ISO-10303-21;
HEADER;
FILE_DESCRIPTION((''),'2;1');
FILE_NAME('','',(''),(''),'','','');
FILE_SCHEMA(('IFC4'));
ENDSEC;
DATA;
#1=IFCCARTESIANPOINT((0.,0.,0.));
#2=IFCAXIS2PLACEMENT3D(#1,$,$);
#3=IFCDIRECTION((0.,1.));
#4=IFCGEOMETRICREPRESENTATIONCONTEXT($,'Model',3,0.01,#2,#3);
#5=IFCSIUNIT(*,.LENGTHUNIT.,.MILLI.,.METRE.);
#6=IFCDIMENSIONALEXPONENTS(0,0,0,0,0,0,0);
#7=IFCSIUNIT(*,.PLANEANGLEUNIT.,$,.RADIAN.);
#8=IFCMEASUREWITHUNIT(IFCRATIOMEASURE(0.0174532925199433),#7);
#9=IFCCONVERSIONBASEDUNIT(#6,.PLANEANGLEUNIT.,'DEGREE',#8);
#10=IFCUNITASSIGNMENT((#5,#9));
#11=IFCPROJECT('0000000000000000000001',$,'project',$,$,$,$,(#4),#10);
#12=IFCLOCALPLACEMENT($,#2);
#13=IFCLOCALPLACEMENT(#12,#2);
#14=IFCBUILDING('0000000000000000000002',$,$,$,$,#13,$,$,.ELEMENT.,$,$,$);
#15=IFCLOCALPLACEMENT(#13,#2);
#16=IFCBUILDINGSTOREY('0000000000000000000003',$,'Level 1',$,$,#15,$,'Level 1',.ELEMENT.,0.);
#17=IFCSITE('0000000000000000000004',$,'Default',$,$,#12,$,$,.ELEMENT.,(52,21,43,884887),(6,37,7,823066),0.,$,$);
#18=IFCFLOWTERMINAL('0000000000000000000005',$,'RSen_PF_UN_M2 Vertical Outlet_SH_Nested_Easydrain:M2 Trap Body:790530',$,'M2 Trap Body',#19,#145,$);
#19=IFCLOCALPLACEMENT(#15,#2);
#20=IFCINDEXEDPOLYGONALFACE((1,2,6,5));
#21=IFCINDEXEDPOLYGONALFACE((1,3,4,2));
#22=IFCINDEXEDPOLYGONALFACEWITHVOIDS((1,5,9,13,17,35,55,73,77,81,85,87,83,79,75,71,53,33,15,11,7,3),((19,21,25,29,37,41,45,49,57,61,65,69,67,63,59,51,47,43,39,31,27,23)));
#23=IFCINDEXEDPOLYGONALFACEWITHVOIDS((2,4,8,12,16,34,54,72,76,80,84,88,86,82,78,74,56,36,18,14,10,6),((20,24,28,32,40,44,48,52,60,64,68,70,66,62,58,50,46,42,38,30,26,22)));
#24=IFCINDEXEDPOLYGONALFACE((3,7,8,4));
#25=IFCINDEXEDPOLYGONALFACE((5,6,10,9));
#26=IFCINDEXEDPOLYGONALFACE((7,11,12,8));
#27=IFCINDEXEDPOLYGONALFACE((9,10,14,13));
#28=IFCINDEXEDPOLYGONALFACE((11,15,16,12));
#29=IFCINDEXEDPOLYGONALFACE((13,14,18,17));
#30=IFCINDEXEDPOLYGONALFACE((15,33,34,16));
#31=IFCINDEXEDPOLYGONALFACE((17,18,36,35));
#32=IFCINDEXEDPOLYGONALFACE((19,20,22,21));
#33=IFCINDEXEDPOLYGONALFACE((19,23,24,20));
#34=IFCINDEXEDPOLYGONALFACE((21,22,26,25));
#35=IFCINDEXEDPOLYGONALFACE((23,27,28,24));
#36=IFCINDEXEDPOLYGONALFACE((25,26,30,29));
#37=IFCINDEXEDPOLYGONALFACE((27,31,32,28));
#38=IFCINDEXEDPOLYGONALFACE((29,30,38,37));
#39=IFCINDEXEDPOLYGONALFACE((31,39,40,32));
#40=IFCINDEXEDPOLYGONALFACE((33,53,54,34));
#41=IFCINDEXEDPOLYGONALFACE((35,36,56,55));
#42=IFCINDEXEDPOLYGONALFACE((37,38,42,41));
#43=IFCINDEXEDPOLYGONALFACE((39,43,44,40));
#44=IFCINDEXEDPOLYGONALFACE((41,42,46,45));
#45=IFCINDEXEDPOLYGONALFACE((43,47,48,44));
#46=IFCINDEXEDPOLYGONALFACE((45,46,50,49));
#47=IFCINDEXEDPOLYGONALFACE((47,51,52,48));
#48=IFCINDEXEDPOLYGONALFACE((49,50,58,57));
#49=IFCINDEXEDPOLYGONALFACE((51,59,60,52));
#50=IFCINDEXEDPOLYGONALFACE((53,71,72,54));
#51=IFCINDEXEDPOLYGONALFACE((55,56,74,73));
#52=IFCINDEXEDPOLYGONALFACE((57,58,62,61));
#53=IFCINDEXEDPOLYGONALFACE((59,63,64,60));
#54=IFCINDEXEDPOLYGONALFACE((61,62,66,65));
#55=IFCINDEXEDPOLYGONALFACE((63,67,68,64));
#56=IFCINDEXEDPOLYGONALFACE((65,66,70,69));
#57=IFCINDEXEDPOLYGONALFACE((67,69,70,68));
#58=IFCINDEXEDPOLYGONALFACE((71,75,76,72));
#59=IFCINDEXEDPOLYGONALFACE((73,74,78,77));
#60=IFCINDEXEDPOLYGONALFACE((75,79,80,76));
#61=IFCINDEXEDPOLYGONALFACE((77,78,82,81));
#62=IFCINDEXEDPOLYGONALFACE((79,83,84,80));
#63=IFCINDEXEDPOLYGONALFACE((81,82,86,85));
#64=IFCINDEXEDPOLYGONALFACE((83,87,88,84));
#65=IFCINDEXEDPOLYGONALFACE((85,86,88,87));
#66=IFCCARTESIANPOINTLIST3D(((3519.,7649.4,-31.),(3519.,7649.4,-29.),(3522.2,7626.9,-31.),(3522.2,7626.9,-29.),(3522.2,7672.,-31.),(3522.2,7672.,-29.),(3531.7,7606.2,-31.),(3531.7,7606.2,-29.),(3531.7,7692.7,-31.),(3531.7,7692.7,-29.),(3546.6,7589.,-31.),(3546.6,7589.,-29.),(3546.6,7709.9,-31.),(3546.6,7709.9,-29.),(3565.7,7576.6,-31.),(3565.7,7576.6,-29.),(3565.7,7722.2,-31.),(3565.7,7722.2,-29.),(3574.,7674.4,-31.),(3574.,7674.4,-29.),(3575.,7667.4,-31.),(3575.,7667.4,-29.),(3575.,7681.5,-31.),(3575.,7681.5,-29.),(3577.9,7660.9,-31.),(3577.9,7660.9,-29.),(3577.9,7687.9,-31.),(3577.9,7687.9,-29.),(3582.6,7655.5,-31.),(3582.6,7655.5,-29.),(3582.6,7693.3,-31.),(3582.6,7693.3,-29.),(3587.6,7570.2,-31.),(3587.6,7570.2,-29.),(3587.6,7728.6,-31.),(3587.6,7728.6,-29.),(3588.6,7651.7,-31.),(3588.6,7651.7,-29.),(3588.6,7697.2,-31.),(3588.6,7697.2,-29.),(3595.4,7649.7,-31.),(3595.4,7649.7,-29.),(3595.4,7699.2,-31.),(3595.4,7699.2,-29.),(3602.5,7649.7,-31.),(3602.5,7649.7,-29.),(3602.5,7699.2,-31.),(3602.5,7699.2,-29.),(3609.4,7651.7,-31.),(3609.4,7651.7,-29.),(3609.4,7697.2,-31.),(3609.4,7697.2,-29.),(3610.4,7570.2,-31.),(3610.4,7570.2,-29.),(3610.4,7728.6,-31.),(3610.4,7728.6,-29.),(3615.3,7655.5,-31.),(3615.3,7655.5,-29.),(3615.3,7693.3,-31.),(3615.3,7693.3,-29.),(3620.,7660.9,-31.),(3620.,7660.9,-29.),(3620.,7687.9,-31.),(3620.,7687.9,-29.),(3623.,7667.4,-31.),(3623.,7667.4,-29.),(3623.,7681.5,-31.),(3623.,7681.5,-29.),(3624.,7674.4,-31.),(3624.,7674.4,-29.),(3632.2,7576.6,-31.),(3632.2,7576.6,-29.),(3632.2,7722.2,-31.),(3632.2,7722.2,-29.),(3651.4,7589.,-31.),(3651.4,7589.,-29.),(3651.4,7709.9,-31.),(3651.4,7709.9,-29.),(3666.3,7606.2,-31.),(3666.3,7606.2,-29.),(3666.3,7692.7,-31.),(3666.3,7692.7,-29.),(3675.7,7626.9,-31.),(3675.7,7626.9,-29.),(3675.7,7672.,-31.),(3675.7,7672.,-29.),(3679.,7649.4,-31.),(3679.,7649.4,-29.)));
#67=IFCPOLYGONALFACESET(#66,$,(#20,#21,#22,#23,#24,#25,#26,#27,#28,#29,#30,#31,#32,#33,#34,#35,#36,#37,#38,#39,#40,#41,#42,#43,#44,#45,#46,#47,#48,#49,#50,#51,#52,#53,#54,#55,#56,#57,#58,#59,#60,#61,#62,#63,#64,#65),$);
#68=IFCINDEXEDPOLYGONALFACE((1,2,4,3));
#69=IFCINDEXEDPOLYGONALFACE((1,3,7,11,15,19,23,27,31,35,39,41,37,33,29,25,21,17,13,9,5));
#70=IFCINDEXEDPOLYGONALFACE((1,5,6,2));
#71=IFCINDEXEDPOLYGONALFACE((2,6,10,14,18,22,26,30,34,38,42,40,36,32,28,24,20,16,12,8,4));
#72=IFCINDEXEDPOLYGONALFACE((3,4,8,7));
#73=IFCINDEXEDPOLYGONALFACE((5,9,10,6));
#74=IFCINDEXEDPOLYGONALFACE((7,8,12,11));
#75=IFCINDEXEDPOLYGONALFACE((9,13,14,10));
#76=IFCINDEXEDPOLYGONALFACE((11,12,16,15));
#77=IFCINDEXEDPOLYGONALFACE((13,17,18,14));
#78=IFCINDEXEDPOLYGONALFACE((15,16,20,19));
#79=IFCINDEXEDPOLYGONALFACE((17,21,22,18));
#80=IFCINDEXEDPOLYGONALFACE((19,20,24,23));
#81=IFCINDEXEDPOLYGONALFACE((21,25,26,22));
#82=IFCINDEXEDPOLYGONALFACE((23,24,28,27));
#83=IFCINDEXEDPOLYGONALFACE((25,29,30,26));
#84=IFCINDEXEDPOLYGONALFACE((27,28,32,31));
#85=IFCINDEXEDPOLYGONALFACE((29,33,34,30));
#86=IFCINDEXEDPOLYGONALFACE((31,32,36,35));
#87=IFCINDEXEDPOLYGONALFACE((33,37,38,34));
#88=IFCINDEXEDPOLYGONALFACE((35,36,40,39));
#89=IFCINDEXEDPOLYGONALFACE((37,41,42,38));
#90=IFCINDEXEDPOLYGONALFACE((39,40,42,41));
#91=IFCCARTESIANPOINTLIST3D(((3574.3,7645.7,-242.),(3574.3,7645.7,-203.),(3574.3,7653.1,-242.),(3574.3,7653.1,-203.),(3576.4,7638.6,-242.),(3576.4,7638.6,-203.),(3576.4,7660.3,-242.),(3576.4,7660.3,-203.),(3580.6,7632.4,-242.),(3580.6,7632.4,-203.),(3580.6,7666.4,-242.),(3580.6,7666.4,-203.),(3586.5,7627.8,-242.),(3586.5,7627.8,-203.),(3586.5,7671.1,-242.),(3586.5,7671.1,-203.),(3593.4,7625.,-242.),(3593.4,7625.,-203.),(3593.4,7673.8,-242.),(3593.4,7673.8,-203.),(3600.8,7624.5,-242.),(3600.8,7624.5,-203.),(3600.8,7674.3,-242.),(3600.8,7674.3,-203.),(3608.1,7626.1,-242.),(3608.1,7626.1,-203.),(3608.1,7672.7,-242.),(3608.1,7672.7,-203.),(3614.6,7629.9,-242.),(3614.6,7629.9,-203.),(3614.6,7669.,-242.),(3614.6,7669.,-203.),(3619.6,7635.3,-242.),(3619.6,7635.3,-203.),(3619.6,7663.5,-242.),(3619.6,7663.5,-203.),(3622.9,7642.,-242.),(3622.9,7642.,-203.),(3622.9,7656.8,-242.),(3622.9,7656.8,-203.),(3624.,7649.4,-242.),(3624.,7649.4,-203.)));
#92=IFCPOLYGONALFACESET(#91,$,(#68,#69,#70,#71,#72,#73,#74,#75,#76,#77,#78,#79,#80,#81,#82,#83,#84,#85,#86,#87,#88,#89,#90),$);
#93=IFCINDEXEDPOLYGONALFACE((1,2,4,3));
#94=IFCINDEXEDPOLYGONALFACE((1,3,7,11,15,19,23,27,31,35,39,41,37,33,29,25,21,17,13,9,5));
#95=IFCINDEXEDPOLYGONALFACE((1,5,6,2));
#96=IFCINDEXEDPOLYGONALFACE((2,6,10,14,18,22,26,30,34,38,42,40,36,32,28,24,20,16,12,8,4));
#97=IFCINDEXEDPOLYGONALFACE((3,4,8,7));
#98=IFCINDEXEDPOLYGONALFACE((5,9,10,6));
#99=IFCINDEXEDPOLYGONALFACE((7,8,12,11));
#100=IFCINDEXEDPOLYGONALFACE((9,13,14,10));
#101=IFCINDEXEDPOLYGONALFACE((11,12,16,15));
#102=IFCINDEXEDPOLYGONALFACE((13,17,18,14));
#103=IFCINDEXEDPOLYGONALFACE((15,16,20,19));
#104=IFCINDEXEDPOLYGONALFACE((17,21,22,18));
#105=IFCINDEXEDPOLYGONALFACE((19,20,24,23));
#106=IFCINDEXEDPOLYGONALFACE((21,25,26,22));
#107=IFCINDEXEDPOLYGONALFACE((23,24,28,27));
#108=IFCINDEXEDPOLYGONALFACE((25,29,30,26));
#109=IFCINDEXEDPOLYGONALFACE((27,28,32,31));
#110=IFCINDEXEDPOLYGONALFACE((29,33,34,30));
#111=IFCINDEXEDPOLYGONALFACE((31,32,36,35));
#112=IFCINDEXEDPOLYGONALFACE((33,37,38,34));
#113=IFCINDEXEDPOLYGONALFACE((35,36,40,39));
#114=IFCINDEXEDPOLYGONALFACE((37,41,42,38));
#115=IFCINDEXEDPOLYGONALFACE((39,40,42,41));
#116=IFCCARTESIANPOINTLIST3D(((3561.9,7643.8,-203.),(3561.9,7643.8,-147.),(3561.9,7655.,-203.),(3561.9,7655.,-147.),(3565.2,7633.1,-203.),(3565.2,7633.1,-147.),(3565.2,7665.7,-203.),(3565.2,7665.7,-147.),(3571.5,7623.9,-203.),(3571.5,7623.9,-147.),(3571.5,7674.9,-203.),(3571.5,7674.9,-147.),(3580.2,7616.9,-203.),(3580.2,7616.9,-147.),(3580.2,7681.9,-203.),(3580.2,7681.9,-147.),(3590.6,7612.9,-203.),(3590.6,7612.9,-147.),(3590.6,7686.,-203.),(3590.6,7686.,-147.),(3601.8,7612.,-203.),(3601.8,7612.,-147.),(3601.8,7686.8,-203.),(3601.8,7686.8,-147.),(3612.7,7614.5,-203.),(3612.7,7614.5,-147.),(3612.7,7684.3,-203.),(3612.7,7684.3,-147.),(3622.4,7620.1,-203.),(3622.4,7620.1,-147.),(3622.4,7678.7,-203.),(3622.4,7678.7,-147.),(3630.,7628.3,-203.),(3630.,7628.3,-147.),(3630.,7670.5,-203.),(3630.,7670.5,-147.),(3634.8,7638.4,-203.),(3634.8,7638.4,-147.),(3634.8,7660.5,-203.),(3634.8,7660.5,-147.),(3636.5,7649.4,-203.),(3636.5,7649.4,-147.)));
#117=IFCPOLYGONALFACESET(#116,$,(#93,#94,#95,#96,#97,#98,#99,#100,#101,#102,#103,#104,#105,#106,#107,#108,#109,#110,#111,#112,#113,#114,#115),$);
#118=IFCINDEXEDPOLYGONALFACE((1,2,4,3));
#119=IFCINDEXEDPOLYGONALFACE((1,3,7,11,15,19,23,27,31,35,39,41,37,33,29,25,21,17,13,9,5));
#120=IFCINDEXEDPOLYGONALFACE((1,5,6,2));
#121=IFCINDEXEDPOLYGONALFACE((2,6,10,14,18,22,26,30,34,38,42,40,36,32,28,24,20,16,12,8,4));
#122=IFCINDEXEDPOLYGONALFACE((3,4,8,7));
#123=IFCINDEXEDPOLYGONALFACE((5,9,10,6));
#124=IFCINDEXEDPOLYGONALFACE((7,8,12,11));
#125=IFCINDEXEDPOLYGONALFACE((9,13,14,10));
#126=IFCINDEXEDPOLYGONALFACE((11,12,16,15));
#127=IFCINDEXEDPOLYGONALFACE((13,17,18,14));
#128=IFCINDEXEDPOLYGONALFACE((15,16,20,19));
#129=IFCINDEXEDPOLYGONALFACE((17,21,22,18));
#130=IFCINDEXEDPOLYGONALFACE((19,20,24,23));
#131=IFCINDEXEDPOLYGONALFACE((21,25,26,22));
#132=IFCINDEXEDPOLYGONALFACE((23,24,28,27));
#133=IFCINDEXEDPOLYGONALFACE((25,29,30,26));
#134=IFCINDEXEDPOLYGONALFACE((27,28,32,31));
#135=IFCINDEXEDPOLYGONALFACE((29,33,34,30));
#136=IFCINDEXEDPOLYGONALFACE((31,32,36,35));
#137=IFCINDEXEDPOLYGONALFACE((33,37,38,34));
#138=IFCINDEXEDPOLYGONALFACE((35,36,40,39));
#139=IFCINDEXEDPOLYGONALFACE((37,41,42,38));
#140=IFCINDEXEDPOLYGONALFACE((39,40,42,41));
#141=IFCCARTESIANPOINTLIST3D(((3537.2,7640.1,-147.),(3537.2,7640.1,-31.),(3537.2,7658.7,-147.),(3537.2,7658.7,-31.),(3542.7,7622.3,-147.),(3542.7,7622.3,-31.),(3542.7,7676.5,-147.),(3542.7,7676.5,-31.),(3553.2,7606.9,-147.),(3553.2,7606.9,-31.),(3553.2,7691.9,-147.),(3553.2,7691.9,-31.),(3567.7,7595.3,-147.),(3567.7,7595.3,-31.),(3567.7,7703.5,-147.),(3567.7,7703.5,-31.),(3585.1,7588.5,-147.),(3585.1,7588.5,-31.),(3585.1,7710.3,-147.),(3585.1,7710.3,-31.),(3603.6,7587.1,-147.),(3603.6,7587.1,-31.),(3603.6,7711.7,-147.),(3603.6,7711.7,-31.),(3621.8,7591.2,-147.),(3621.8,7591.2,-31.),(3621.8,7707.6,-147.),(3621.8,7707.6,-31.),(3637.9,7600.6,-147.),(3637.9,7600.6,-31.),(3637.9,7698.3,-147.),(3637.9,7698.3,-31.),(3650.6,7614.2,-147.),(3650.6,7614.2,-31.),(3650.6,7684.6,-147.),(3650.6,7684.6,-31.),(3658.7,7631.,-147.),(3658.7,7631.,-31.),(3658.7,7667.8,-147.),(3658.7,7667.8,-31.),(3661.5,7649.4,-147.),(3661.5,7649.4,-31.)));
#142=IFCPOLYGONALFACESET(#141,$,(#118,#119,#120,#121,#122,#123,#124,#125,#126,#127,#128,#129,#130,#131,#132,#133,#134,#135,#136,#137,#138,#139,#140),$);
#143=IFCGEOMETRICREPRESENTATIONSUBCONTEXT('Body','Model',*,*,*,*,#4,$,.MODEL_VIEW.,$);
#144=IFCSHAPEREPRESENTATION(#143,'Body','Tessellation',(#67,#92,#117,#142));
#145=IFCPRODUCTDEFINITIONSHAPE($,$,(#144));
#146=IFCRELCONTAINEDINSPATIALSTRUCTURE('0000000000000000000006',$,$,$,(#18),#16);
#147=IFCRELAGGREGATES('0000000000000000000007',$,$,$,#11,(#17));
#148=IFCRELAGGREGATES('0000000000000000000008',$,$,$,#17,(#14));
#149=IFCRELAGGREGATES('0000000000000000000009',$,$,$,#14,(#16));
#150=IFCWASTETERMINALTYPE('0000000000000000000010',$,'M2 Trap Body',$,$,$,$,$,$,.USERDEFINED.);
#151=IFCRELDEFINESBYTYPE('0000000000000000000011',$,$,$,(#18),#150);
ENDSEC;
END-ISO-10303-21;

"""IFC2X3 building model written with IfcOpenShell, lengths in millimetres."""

from ifc_helpers import new_model, entity, si_unit, converted_unit, direction, frame, frame_2d, origin, origin_2d_with_axis, place, context, subcontext, project, spatial, circle_curve, parameter, trimmed, segment, composite_curve, circle, outline, extrude, source, transform, mapped, type_object, type_shapes, element, save


model = new_model("IFC2X3")

# Units and contexts
model_context = context("Model", 3, precision=0.01, world=origin(), true_north=direction((0.0, 1.0)))
body_context = subcontext(model_context, "Body", "Model", "MODEL_VIEW")
ifc_project = project(units=[si_unit("LENGTHUNIT", "METRE", prefix="MILLI"), converted_unit("PLANEANGLEUNIT", "DEGREE", entity("IfcRatioMeasure", 0.0174532925199433), si_unit("PLANEANGLEUNIT", "RADIAN"), dimensions=[0, 0, 0, 0, 0, 0, 0])], contexts=[model_context])

# Site, building, storey
site_placement = place(None, origin())
site = spatial("IfcSite", under=ifc_project, at=site_placement, Name="Default", CompositionType="ELEMENT", RefLatitude=(52, 21, 43, 884887), RefLongitude=(6, 37, 7, 823066), RefElevation=0.0)
building_placement = place(site_placement, origin())
building = spatial("IfcBuilding", under=site, at=building_placement, CompositionType="ELEMENT")
storey_placement = place(building_placement, origin())
storey = spatial("IfcBuildingStorey", under=building, at=storey_placement, Name="Level 1", LongName="Level 1", CompositionType="ELEMENT", Elevation=0.0)

# Flow terminal
waste_terminal_type_1 = type_object("IfcWasteTerminalType", Name="M2 Trap Body", PredefinedType="USERDEFINED")
shared_shape_1 = source(origin(), body_context, "Body", "SweptSolid", [
    extrude(outline(composite_curve([segment(trimmed(circle_curve(origin_2d_with_axis(), 80.0), [parameter(0.0)], [parameter(180.0)], True, "PARAMETER"), True, "CONTINUOUS"), segment(trimmed(circle_curve(origin_2d_with_axis(), 80.0), [parameter(180.0)], [parameter(360.0)], True, "PARAMETER"), True, "CONTINUOUS")], self_intersect=False), holes=[composite_curve([segment(trimmed(circle_curve(frame_2d((0.0, 25.0), x_axis=(1.0, 0.0)), 25.0), [parameter(180.0)], [parameter(360.0)], True, "PARAMETER"), False, "CONTINUOUS"), segment(trimmed(circle_curve(frame_2d((0.0, 25.0), x_axis=(1.0, 0.0)), 25.0), [parameter(0.0)], [parameter(180.0)], True, "PARAMETER"), False, "CONTINUOUS")], self_intersect=False)]), frame((0.0, -25.0, -2.0)), (0.0, 0.0, 1.0), 2.0),
    extrude(circle(Radius=25.0, at=frame_2d((0.0, 0.0), x_axis=(1.0, 0.0))), frame((0.0, -25.0, -213.0)), (0.0, 0.0, 1.0), 39.0),
    extrude(circle(Radius=37.5, at=frame_2d((0.0, 0.0), x_axis=(1.0, 0.0))), frame((0.0, -25.0, -174.0)), (0.0, 0.0, 1.0), 56.0),
    extrude(circle(Radius=62.5, at=frame_2d((0.0, 0.0), x_axis=(1.0, 0.0))), frame((0.0, -25.0, -118.0)), (0.0, 0.0, 1.0), 116.0),
])
type_shapes(waste_terminal_type_1, [shared_shape_1])
for number, where, name in (
    (1, (3599.0, 7674.4, -29.0), "RSen_PF_UN_M2 Vertical Outlet_SH_Nested_Easydrain:M2 Trap Body:790530"),
):
    element("IfcFlowTerminal", number, at=place(storey_placement, frame(where)), inside=storey, type_object=waste_terminal_type_1, Name=name, ObjectType="M2 Trap Body", context=body_context, shape_type="MappedRepresentation", body=[
        mapped(shared_shape_1, transform((0.0, 0.0, 0.0), scale=1.0)),
    ])

save(model, "model.ifc")
